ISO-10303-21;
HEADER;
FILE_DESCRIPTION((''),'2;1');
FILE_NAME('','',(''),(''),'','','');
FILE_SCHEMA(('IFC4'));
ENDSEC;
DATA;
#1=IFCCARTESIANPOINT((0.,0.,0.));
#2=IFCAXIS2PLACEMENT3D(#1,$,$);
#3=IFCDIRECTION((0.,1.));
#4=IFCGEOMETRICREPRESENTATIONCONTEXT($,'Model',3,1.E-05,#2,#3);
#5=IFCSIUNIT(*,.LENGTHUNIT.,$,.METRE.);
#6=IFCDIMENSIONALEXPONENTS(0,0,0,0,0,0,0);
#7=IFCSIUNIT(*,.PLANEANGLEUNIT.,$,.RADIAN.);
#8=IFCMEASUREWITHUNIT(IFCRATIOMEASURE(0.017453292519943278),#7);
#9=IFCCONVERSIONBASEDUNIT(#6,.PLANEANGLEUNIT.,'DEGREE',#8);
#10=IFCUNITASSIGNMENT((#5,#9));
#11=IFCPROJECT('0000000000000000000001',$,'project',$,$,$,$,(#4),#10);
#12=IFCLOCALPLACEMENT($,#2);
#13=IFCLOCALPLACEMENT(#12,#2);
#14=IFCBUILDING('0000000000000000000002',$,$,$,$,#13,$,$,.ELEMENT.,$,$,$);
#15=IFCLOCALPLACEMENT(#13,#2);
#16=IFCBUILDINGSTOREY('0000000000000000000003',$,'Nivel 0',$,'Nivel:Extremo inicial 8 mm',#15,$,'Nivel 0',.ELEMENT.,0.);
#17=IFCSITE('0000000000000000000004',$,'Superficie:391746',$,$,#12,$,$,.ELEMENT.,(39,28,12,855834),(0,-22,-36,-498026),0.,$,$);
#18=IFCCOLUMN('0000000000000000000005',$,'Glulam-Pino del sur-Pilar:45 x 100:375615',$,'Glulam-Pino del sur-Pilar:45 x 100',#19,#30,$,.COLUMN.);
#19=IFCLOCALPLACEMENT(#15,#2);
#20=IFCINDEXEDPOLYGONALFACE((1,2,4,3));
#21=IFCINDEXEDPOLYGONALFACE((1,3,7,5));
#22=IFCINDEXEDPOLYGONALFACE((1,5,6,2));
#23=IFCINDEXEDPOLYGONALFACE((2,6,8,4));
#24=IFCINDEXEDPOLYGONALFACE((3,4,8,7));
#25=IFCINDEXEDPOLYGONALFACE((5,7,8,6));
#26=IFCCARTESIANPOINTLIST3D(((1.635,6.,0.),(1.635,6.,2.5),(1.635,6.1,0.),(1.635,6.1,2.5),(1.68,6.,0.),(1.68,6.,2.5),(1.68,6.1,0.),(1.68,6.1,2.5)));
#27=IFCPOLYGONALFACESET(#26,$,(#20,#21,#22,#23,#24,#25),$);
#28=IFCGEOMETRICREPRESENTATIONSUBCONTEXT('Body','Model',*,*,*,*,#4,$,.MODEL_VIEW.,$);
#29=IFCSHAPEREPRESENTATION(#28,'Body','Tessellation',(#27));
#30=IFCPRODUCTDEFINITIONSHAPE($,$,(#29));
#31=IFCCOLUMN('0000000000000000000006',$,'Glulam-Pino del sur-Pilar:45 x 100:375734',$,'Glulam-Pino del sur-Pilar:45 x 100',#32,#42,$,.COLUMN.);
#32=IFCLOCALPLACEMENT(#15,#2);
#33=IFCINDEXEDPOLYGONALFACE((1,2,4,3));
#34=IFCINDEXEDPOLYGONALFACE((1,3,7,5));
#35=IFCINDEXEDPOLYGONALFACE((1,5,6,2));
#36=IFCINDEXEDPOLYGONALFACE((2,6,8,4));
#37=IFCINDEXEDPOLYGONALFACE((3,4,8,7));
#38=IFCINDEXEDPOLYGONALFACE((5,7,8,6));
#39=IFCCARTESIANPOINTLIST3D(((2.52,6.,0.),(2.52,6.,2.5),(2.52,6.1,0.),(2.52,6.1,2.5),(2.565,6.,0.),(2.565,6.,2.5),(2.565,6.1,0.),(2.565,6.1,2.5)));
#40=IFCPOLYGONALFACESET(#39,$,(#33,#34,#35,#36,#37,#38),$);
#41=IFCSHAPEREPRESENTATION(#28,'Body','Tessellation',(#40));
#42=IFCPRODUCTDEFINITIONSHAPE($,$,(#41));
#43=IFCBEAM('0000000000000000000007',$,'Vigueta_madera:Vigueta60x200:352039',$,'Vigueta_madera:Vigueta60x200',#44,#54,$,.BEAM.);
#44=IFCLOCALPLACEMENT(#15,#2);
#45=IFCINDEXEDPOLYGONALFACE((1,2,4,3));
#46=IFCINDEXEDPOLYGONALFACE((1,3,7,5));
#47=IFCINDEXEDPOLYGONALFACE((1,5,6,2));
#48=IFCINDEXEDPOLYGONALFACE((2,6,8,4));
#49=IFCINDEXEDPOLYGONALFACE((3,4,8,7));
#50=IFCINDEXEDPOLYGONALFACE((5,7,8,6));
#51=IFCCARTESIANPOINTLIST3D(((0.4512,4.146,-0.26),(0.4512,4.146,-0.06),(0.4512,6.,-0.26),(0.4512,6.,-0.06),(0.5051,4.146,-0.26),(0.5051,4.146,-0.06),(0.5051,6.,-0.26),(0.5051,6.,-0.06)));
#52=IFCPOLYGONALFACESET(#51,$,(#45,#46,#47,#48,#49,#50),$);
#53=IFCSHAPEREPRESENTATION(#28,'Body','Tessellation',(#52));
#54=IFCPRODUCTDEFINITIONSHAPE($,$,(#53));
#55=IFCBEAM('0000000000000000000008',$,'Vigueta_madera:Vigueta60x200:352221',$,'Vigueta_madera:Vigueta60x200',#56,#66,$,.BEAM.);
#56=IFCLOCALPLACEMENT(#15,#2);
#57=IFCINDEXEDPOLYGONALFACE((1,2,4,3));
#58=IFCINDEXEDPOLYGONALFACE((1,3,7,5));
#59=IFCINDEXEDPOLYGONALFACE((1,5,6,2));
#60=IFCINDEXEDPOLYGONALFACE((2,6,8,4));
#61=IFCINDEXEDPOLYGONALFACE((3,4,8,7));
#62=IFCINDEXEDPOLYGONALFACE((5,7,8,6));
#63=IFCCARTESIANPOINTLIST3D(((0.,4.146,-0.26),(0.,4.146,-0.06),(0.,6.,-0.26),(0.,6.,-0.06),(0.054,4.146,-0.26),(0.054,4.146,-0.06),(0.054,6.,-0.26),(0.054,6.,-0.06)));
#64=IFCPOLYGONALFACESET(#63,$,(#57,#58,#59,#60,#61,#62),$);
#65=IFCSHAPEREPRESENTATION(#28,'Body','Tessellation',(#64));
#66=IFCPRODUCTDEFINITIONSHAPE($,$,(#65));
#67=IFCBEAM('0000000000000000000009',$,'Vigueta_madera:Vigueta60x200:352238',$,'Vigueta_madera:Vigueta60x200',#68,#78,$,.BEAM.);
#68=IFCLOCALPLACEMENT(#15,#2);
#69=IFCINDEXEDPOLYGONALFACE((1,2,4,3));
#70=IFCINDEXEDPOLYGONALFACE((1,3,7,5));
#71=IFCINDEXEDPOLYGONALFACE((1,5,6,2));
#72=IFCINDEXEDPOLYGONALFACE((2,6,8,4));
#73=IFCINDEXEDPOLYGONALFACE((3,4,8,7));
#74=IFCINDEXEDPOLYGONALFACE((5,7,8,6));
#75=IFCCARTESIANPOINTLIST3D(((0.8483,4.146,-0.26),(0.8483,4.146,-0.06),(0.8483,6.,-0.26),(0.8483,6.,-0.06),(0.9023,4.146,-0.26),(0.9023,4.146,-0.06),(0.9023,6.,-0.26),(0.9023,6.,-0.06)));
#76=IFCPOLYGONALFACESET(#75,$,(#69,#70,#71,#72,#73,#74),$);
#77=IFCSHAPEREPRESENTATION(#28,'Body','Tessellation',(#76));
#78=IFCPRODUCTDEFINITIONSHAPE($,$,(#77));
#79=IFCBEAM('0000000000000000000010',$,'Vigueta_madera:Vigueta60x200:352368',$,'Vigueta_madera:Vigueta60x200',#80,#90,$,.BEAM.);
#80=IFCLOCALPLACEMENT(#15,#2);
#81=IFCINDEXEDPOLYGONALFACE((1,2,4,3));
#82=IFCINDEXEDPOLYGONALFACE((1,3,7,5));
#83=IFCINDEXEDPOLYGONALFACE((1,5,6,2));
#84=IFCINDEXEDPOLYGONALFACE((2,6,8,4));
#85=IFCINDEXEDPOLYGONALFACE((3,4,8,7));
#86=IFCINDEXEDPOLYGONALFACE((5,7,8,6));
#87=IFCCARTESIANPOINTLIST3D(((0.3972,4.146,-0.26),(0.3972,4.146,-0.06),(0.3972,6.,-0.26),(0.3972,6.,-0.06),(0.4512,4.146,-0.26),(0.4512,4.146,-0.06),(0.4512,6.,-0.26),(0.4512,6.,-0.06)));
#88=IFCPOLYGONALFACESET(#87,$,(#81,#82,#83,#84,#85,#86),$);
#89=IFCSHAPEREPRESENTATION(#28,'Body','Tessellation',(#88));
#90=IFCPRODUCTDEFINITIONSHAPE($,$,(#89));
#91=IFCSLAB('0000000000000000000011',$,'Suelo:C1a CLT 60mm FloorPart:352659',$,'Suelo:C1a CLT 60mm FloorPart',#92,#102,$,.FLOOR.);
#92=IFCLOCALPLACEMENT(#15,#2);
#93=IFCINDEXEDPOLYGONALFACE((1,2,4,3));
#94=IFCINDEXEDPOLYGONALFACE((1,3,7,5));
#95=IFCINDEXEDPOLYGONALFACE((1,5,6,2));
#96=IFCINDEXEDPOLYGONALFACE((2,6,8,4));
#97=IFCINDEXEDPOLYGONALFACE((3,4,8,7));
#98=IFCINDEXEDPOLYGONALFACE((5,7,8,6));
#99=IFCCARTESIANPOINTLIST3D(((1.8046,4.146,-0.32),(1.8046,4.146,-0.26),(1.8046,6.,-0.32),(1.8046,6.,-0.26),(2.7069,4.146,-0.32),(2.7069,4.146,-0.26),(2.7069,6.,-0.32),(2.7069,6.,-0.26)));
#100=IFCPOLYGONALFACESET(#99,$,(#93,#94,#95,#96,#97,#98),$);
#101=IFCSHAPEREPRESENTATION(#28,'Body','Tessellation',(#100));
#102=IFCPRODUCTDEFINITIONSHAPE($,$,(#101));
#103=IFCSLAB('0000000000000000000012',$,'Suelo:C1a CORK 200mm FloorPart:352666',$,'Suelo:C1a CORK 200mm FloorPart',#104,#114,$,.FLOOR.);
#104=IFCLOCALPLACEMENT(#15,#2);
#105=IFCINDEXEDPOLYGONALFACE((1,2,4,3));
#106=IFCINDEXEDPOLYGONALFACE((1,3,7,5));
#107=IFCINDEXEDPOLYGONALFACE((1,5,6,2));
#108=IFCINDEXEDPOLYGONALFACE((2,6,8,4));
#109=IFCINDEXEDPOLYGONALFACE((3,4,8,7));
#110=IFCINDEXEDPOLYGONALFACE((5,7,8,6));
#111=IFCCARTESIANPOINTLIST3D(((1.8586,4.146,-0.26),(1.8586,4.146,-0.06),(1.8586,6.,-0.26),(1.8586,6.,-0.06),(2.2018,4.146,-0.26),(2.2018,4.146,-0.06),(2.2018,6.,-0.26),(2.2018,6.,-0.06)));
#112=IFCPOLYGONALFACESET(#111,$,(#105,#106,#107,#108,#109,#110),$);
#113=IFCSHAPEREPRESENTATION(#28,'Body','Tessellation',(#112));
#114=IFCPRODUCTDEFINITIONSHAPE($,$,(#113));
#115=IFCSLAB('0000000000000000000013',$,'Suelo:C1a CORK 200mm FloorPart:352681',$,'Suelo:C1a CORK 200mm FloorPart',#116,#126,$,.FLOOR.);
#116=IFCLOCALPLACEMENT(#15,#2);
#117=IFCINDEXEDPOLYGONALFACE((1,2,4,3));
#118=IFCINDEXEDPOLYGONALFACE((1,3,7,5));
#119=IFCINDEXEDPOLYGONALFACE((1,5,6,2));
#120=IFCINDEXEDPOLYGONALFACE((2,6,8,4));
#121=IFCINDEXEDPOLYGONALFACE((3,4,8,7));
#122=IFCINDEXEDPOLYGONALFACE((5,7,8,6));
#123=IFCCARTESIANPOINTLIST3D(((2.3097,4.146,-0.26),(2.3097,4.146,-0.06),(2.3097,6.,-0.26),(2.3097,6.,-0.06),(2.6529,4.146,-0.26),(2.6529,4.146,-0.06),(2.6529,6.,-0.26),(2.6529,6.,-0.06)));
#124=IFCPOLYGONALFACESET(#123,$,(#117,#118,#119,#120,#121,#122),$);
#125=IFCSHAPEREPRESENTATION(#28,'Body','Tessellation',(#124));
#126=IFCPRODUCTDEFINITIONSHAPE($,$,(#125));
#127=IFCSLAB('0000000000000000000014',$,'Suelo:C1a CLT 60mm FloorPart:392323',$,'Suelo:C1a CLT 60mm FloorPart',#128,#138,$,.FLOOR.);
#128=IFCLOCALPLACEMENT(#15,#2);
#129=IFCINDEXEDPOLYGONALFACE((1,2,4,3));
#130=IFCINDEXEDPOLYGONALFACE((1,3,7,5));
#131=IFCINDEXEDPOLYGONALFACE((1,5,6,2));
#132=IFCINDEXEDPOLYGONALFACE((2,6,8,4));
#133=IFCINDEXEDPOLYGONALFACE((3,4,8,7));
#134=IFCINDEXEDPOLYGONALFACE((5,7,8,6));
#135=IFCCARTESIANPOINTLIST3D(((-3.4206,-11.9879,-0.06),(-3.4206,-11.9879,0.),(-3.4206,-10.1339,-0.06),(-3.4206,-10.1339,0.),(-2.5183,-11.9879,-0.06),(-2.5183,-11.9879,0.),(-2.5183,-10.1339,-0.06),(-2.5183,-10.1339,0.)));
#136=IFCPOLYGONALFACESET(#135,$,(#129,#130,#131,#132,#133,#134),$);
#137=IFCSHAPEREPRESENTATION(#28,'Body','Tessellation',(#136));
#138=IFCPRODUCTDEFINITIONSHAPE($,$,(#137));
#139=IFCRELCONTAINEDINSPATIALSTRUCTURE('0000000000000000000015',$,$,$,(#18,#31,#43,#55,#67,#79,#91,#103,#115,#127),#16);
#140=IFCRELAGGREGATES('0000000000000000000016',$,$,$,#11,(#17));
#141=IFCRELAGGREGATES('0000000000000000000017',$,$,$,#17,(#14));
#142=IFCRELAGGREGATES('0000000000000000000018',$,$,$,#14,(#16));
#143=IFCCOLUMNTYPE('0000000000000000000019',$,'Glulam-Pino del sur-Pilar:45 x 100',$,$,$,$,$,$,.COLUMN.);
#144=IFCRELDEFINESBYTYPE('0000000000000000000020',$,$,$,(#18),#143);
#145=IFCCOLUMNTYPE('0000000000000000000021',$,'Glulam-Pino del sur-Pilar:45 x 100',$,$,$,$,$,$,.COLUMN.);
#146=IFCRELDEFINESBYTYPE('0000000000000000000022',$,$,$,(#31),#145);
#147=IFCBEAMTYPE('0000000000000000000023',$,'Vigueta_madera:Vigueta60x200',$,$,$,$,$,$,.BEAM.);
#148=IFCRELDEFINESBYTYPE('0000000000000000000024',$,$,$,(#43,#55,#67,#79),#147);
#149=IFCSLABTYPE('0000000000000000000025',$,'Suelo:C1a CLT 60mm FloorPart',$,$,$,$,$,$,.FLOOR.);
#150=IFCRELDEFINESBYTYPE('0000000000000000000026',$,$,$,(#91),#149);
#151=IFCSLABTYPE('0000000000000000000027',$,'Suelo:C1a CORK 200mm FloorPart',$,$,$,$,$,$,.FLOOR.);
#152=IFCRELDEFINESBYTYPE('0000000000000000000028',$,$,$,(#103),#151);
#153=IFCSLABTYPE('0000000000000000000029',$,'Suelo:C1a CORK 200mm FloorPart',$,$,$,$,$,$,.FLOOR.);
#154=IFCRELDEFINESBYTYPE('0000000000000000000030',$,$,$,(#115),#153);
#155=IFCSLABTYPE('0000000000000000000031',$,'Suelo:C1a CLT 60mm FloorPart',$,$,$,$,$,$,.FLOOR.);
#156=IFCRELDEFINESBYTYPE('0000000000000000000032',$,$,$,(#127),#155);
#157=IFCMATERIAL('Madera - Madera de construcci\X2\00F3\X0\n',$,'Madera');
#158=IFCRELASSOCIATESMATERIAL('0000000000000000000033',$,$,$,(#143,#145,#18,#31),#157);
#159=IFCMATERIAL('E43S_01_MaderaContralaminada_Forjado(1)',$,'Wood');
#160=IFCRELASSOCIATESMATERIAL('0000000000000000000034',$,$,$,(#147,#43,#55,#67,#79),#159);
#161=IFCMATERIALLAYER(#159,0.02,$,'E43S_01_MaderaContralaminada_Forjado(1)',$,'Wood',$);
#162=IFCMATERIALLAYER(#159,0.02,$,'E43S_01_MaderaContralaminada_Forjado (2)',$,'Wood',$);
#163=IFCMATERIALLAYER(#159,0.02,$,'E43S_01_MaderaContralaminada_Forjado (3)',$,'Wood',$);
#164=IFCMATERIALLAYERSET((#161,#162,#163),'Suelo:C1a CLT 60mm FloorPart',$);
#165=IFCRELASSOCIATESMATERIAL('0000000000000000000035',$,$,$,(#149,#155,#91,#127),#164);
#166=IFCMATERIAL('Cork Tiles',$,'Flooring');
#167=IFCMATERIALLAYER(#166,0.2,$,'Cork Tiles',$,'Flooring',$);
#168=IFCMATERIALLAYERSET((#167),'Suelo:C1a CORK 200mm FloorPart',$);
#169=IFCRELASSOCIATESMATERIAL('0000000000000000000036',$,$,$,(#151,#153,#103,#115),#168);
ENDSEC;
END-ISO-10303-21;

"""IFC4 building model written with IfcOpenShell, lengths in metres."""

from ifc_helpers import new_model, entity, si_unit, converted_unit, direction, frame, frame_2d, origin, origin_2d_with_axis, place, context, subcontext, project, spatial, polyline, segment, composite_curve, rectangle, outline, extrude, source, transform, mapped, material, layer, layer_set, layer_usage, material_profile, profile_set, profile_usage, type_object, type_shapes, element, save


model = new_model("IFC4")

# Units and contexts
model_context = context("Model", 3, precision=1e-05, world=origin(), true_north=direction((0.0, 1.0)))
body_context = subcontext(model_context, "Body", "Model", "MODEL_VIEW")
ifc_project = project(units=[si_unit("LENGTHUNIT", "METRE"), converted_unit("PLANEANGLEUNIT", "DEGREE", entity("IfcRatioMeasure", 0.017453292519943278), si_unit("PLANEANGLEUNIT", "RADIAN"), dimensions=[0, 0, 0, 0, 0, 0, 0])], contexts=[model_context])

# Site, building, storey
site_placement = place(None, origin())
site = spatial("IfcSite", under=ifc_project, at=site_placement, Name="Superficie:391746", CompositionType="ELEMENT", RefLatitude=(39, 28, 12, 855834), RefLongitude=(0, -22, -36, -498026), RefElevation=0.0)
building_placement = place(site_placement, origin())
building = spatial("IfcBuilding", under=site, at=building_placement, CompositionType="ELEMENT")
storey_placement = place(building_placement, origin())
storey = spatial("IfcBuildingStorey", under=building, at=storey_placement, Name="Nivel 0", ObjectType="Nivel:Extremo inicial 8 mm", LongName="Nivel 0", CompositionType="ELEMENT", Elevation=0.0)

# Columns
ifc_material_1 = material(Name="Madera - Madera de construcción", Category="Madera")
ifc_material_profile_1 = material_profile(ifc_material_1, outline(composite_curve([segment(polyline([(0.0225, 0.05, 0.0), (0.0225, -0.05, 0.0)]), True, "CONTINUOUS"), segment(polyline([(0.0225, -0.05, 0.0), (-0.0225, -0.05, 0.0)]), True, "CONTINUOUS"), segment(polyline([(-0.0225, -0.05, 0.0), (-0.0225, 0.05, 0.0)]), True, "CONTINUOUS"), segment(polyline([(-0.0225, 0.05, 0.0), (0.0225, 0.05, 0.0)]), True, "CONTINUOUS")], self_intersect=False), kind="CURVE"), Name="45 x 100")
ifc_material_profile_2 = material_profile(ifc_material_1, outline(composite_curve([segment(polyline([(0.0225, 0.05, 2.5), (-0.0225, 0.05, 2.5)]), True, "CONTINUOUS"), segment(polyline([(-0.0225, 0.05, 2.5), (-0.0225, -0.05, 2.5)]), True, "CONTINUOUS"), segment(polyline([(-0.0225, -0.05, 2.5), (0.0225, -0.05, 2.5)]), True, "CONTINUOUS"), segment(polyline([(0.0225, -0.05, 2.5), (0.0225, 0.05, 2.5)]), True, "CONTINUOUS")], self_intersect=False), kind="CURVE"), Name="45 x 100")
ifc_profile_set_1 = profile_set([ifc_material_profile_1, ifc_material_profile_2], Name="45 x 100")
ifc_profile_usage_1 = profile_usage(ifc_profile_set_1)
column_type_1 = type_object("IfcColumnType", Name="Glulam-Pino del sur-Pilar:45 x 100", PredefinedType="COLUMN", material=ifc_profile_set_1)
shared_shape_1 = source(origin(), body_context, "Body", "SweptSolid", [
    extrude(rectangle(XDim=0.1, YDim=0.045, at=origin_2d_with_axis()), frame((0.0, 0.0, 0.0), z_axis=(0.0, 0.0, 1.0), x_axis=(0.0, -1.0, 0.0)), (0.0, 0.0, 1.0), 2.5),
])
type_shapes(column_type_1, [shared_shape_1])
column_1_placement = place(storey_placement, frame((1.6575, 6.05, 0.0)))
element("IfcColumn", 1, at=column_1_placement, inside=storey, type_object=column_type_1, material=ifc_profile_usage_1, Name="Glulam-Pino del sur-Pilar:45 x 100:375615", ObjectType="Glulam-Pino del sur-Pilar:45 x 100", PredefinedType="COLUMN", context=body_context, shape_type="MappedRepresentation", body=[
    mapped(shared_shape_1, transform((0.0, 0.0, 0.0), scale=1.0)),
])
ifc_profile_usage_2 = profile_usage(ifc_profile_set_1)
column_type_2 = type_object("IfcColumnType", Name="Glulam-Pino del sur-Pilar:45 x 100", PredefinedType="COLUMN", material=ifc_profile_set_1)
shared_shape_2 = source(origin(), body_context, "Body", "SweptSolid", [
    extrude(rectangle(XDim=0.1, YDim=0.045, at=origin_2d_with_axis()), frame((0.0, 0.0, 0.0), z_axis=(0.0, 0.0, 1.0), x_axis=(0.0, -1.0, 0.0)), (0.0, 0.0, 1.0), 2.5),
])
type_shapes(column_type_2, [shared_shape_2])
column_2_placement = place(storey_placement, frame((2.5425, 6.05, 0.0), z_axis=(0.0, 0.0, 1.0), x_axis=(-1.0, 0.0, 0.0)))
element("IfcColumn", 2, at=column_2_placement, inside=storey, type_object=column_type_2, material=ifc_profile_usage_2, Name="Glulam-Pino del sur-Pilar:45 x 100:375734", ObjectType="Glulam-Pino del sur-Pilar:45 x 100", PredefinedType="COLUMN", context=body_context, shape_type="MappedRepresentation", body=[
    mapped(shared_shape_2, transform((0.0, 0.0, 0.0), scale=1.0)),
])

# Beams
ifc_material_2 = material(Name="E43S_01_MaderaContralaminada_Forjado(1)", Category="Wood")
ifc_material_profile_3 = material_profile(ifc_material_2, outline(composite_curve([segment(polyline([(-0.027, -0.1, 0.0), (-0.027, 0.1, 0.0)]), True, "CONTINUOUS"), segment(polyline([(-0.027, 0.1, 0.0), (0.027, 0.1, 0.0)]), True, "CONTINUOUS"), segment(polyline([(0.027, 0.1, 0.0), (0.027, -0.1, 0.0)]), True, "CONTINUOUS"), segment(polyline([(0.027, -0.1, 0.0), (-0.027, -0.1, 0.0)]), True, "CONTINUOUS")], self_intersect=False), kind="CURVE"), Name="Vigueta60x200")
ifc_material_profile_4 = material_profile(ifc_material_2, outline(composite_curve([segment(polyline([(0.927, -0.027, -0.1), (0.927, -0.027, 0.1)]), True, "CONTINUOUS"), segment(polyline([(0.927, -0.027, 0.1), (-0.927, -0.027, 0.1)]), True, "CONTINUOUS"), segment(polyline([(-0.927, -0.027, 0.1), (-0.927, -0.027, -0.1)]), True, "CONTINUOUS"), segment(polyline([(-0.927, -0.027, -0.1), (0.927, -0.027, -0.1)]), True, "CONTINUOUS")], self_intersect=False), kind="CURVE"), Name="Vigueta60x200")
ifc_profile_set_2 = profile_set([ifc_material_profile_3, ifc_material_profile_4], Name="Vigueta60x200")
ifc_profile_usage_3 = profile_usage(ifc_profile_set_2, cardinal=8)
beam_type = type_object("IfcBeamType", Name="Vigueta_madera:Vigueta60x200", PredefinedType="BEAM", material=ifc_profile_set_2)
shared_shape_3 = source(origin(), body_context, "Body", "SweptSolid", [
    extrude(rectangle(XDim=0.2, YDim=0.054, at=frame_2d((0.0, 0.0), x_axis=(1.0, 0.0))), frame((-0.927, 0.0, 0.0), z_axis=(1.0, 0.0, 0.0), x_axis=(0.0, 0.0, -1.0)), (0.0, 0.0, 1.0), 1.854),
])
type_shapes(beam_type, [shared_shape_3])
beam_1_placement = place(storey_placement, frame((0.4781, 5.073, -0.16), z_axis=(0.0, 0.0, 1.0), x_axis=(0.0, 1.0, 0.0)))
element("IfcBeam", 3, at=beam_1_placement, inside=storey, type_object=beam_type, material=ifc_profile_usage_3, Name="Vigueta_madera:Vigueta60x200:352039", ObjectType="Vigueta_madera:Vigueta60x200", PredefinedType="BEAM", context=body_context, shape_type="MappedRepresentation", body=[
    mapped(shared_shape_3, transform((0.0, 0.0, 0.0), scale=1.0)),
])
ifc_profile_usage_4 = profile_usage(ifc_profile_set_2, cardinal=8)
beam_2_placement = place(storey_placement, frame((0.027, 5.073, -0.16), z_axis=(0.0, 0.0, 1.0), x_axis=(0.0, 1.0, 0.0)))
element("IfcBeam", 4, at=beam_2_placement, inside=storey, type_object=beam_type, material=ifc_profile_usage_4, Name="Vigueta_madera:Vigueta60x200:352221", ObjectType="Vigueta_madera:Vigueta60x200", PredefinedType="BEAM", context=body_context, shape_type="MappedRepresentation", body=[
    mapped(shared_shape_3, transform((0.0, 0.0, 0.0), scale=1.0)),
])
ifc_profile_usage_5 = profile_usage(ifc_profile_set_2, cardinal=8)
beam_3_placement = place(storey_placement, frame((0.8753, 5.073, -0.16), z_axis=(0.0, 0.0, 1.0), x_axis=(0.0, 1.0, 0.0)))
element("IfcBeam", 5, at=beam_3_placement, inside=storey, type_object=beam_type, material=ifc_profile_usage_5, Name="Vigueta_madera:Vigueta60x200:352238", ObjectType="Vigueta_madera:Vigueta60x200", PredefinedType="BEAM", context=body_context, shape_type="MappedRepresentation", body=[
    mapped(shared_shape_3, transform((0.0, 0.0, 0.0), scale=1.0)),
])
ifc_profile_usage_6 = profile_usage(ifc_profile_set_2, cardinal=8)
beam_4_placement = place(storey_placement, frame((0.4242, 5.073, -0.16), z_axis=(0.0, 0.0, 1.0), x_axis=(0.0, 1.0, 0.0)))
element("IfcBeam", 6, at=beam_4_placement, inside=storey, type_object=beam_type, material=ifc_profile_usage_6, Name="Vigueta_madera:Vigueta60x200:352368", ObjectType="Vigueta_madera:Vigueta60x200", PredefinedType="BEAM", context=body_context, shape_type="MappedRepresentation", body=[
    mapped(shared_shape_3, transform((0.0, 0.0, 0.0), scale=1.0)),
])

# Slabs
ifc_layer_1 = layer(ifc_material_2, 0.02, Name="E43S_01_MaderaContralaminada_Forjado(1)", Category="Wood")
ifc_layer_2 = layer(ifc_material_2, 0.02, Name="E43S_01_MaderaContralaminada_Forjado (2)", Category="Wood")
ifc_layer_3 = layer(ifc_material_2, 0.02, Name="E43S_01_MaderaContralaminada_Forjado (3)", Category="Wood")
ifc_layer_set_1 = layer_set([ifc_layer_1, ifc_layer_2, ifc_layer_3], Name="Suelo:C1a CLT 60mm FloorPart")
ifc_layer_usage_1 = layer_usage(ifc_layer_set_1, "AXIS3", "POSITIVE", 0.0)
slab_type_1 = type_object("IfcSlabType", Name="Suelo:C1a CLT 60mm FloorPart", PredefinedType="FLOOR", material=ifc_layer_set_1)
slab_1_placement = place(storey_placement, origin())
element("IfcSlab", 7, at=slab_1_placement, inside=storey, type_object=slab_type_1, material=ifc_layer_usage_1, Name="Suelo:C1a CLT 60mm FloorPart:352659", ObjectType="Suelo:C1a CLT 60mm FloorPart", PredefinedType="FLOOR", context=body_context, shape_type="SweptSolid", body=[
    extrude(rectangle(XDim=1.854, YDim=0.9023, at=frame_2d((0.0, 0.0), x_axis=(1.0, 0.0))), frame((2.2558, 5.073, -0.26), z_axis=(0.0, 0.0, -1.0), x_axis=(0.0, 1.0, 0.0)), (0.0, 0.0, 1.0), 0.06),
])
ifc_material_3 = material(Name="Cork Tiles", Category="Flooring")
ifc_layer_4 = layer(ifc_material_3, 0.2, Name="Cork Tiles", Category="Flooring")
ifc_layer_set_2 = layer_set([ifc_layer_4], Name="Suelo:C1a CORK 200mm FloorPart")
ifc_layer_usage_2 = layer_usage(ifc_layer_set_2, "AXIS3", "POSITIVE", 0.0)
slab_type_2 = type_object("IfcSlabType", Name="Suelo:C1a CORK 200mm FloorPart", PredefinedType="FLOOR", material=ifc_layer_set_2)
slab_2_placement = place(storey_placement, origin())
element("IfcSlab", 8, at=slab_2_placement, inside=storey, type_object=slab_type_2, material=ifc_layer_usage_2, Name="Suelo:C1a CORK 200mm FloorPart:352666", ObjectType="Suelo:C1a CORK 200mm FloorPart", PredefinedType="FLOOR", context=body_context, shape_type="SweptSolid", body=[
    extrude(rectangle(XDim=1.854, YDim=0.3432, at=frame_2d((0.0, 0.0), x_axis=(1.0, 0.0))), frame((2.0302, 5.073, -0.06), z_axis=(0.0, 0.0, -1.0), x_axis=(0.0, 1.0, 0.0)), (0.0, 0.0, 1.0), 0.2),
])
ifc_layer_usage_3 = layer_usage(ifc_layer_set_2, "AXIS3", "POSITIVE", 0.0)
slab_type_3 = type_object("IfcSlabType", Name="Suelo:C1a CORK 200mm FloorPart", PredefinedType="FLOOR", material=ifc_layer_set_2)
slab_3_placement = place(storey_placement, origin())
element("IfcSlab", 9, at=slab_3_placement, inside=storey, type_object=slab_type_3, material=ifc_layer_usage_3, Name="Suelo:C1a CORK 200mm FloorPart:352681", ObjectType="Suelo:C1a CORK 200mm FloorPart", PredefinedType="FLOOR", context=body_context, shape_type="SweptSolid", body=[
    extrude(rectangle(XDim=1.854, YDim=0.3432, at=origin_2d_with_axis()), frame((2.4813, 5.073, -0.06), z_axis=(0.0, 0.0, -1.0), x_axis=(0.0, 1.0, 0.0)), (0.0, 0.0, 1.0), 0.2),
])
ifc_layer_usage_4 = layer_usage(ifc_layer_set_1, "AXIS3", "POSITIVE", 0.0)
slab_type_4 = type_object("IfcSlabType", Name="Suelo:C1a CLT 60mm FloorPart", PredefinedType="FLOOR", material=ifc_layer_set_1)
slab_4_placement = place(storey_placement, origin())
element("IfcSlab", 10, at=slab_4_placement, inside=storey, type_object=slab_type_4, material=ifc_layer_usage_4, Name="Suelo:C1a CLT 60mm FloorPart:392323", ObjectType="Suelo:C1a CLT 60mm FloorPart", PredefinedType="FLOOR", context=body_context, shape_type="SweptSolid", body=[
    extrude(rectangle(XDim=1.854, YDim=0.9023, at=frame_2d((0.0, 0.0), x_axis=(1.0, 0.0))), frame((-2.9695, -11.0609, 0.0), z_axis=(0.0, 0.0, -1.0), x_axis=(0.0, 1.0, 0.0)), (0.0, 0.0, 1.0), 0.06),
])

save(model, "model.ifc")
